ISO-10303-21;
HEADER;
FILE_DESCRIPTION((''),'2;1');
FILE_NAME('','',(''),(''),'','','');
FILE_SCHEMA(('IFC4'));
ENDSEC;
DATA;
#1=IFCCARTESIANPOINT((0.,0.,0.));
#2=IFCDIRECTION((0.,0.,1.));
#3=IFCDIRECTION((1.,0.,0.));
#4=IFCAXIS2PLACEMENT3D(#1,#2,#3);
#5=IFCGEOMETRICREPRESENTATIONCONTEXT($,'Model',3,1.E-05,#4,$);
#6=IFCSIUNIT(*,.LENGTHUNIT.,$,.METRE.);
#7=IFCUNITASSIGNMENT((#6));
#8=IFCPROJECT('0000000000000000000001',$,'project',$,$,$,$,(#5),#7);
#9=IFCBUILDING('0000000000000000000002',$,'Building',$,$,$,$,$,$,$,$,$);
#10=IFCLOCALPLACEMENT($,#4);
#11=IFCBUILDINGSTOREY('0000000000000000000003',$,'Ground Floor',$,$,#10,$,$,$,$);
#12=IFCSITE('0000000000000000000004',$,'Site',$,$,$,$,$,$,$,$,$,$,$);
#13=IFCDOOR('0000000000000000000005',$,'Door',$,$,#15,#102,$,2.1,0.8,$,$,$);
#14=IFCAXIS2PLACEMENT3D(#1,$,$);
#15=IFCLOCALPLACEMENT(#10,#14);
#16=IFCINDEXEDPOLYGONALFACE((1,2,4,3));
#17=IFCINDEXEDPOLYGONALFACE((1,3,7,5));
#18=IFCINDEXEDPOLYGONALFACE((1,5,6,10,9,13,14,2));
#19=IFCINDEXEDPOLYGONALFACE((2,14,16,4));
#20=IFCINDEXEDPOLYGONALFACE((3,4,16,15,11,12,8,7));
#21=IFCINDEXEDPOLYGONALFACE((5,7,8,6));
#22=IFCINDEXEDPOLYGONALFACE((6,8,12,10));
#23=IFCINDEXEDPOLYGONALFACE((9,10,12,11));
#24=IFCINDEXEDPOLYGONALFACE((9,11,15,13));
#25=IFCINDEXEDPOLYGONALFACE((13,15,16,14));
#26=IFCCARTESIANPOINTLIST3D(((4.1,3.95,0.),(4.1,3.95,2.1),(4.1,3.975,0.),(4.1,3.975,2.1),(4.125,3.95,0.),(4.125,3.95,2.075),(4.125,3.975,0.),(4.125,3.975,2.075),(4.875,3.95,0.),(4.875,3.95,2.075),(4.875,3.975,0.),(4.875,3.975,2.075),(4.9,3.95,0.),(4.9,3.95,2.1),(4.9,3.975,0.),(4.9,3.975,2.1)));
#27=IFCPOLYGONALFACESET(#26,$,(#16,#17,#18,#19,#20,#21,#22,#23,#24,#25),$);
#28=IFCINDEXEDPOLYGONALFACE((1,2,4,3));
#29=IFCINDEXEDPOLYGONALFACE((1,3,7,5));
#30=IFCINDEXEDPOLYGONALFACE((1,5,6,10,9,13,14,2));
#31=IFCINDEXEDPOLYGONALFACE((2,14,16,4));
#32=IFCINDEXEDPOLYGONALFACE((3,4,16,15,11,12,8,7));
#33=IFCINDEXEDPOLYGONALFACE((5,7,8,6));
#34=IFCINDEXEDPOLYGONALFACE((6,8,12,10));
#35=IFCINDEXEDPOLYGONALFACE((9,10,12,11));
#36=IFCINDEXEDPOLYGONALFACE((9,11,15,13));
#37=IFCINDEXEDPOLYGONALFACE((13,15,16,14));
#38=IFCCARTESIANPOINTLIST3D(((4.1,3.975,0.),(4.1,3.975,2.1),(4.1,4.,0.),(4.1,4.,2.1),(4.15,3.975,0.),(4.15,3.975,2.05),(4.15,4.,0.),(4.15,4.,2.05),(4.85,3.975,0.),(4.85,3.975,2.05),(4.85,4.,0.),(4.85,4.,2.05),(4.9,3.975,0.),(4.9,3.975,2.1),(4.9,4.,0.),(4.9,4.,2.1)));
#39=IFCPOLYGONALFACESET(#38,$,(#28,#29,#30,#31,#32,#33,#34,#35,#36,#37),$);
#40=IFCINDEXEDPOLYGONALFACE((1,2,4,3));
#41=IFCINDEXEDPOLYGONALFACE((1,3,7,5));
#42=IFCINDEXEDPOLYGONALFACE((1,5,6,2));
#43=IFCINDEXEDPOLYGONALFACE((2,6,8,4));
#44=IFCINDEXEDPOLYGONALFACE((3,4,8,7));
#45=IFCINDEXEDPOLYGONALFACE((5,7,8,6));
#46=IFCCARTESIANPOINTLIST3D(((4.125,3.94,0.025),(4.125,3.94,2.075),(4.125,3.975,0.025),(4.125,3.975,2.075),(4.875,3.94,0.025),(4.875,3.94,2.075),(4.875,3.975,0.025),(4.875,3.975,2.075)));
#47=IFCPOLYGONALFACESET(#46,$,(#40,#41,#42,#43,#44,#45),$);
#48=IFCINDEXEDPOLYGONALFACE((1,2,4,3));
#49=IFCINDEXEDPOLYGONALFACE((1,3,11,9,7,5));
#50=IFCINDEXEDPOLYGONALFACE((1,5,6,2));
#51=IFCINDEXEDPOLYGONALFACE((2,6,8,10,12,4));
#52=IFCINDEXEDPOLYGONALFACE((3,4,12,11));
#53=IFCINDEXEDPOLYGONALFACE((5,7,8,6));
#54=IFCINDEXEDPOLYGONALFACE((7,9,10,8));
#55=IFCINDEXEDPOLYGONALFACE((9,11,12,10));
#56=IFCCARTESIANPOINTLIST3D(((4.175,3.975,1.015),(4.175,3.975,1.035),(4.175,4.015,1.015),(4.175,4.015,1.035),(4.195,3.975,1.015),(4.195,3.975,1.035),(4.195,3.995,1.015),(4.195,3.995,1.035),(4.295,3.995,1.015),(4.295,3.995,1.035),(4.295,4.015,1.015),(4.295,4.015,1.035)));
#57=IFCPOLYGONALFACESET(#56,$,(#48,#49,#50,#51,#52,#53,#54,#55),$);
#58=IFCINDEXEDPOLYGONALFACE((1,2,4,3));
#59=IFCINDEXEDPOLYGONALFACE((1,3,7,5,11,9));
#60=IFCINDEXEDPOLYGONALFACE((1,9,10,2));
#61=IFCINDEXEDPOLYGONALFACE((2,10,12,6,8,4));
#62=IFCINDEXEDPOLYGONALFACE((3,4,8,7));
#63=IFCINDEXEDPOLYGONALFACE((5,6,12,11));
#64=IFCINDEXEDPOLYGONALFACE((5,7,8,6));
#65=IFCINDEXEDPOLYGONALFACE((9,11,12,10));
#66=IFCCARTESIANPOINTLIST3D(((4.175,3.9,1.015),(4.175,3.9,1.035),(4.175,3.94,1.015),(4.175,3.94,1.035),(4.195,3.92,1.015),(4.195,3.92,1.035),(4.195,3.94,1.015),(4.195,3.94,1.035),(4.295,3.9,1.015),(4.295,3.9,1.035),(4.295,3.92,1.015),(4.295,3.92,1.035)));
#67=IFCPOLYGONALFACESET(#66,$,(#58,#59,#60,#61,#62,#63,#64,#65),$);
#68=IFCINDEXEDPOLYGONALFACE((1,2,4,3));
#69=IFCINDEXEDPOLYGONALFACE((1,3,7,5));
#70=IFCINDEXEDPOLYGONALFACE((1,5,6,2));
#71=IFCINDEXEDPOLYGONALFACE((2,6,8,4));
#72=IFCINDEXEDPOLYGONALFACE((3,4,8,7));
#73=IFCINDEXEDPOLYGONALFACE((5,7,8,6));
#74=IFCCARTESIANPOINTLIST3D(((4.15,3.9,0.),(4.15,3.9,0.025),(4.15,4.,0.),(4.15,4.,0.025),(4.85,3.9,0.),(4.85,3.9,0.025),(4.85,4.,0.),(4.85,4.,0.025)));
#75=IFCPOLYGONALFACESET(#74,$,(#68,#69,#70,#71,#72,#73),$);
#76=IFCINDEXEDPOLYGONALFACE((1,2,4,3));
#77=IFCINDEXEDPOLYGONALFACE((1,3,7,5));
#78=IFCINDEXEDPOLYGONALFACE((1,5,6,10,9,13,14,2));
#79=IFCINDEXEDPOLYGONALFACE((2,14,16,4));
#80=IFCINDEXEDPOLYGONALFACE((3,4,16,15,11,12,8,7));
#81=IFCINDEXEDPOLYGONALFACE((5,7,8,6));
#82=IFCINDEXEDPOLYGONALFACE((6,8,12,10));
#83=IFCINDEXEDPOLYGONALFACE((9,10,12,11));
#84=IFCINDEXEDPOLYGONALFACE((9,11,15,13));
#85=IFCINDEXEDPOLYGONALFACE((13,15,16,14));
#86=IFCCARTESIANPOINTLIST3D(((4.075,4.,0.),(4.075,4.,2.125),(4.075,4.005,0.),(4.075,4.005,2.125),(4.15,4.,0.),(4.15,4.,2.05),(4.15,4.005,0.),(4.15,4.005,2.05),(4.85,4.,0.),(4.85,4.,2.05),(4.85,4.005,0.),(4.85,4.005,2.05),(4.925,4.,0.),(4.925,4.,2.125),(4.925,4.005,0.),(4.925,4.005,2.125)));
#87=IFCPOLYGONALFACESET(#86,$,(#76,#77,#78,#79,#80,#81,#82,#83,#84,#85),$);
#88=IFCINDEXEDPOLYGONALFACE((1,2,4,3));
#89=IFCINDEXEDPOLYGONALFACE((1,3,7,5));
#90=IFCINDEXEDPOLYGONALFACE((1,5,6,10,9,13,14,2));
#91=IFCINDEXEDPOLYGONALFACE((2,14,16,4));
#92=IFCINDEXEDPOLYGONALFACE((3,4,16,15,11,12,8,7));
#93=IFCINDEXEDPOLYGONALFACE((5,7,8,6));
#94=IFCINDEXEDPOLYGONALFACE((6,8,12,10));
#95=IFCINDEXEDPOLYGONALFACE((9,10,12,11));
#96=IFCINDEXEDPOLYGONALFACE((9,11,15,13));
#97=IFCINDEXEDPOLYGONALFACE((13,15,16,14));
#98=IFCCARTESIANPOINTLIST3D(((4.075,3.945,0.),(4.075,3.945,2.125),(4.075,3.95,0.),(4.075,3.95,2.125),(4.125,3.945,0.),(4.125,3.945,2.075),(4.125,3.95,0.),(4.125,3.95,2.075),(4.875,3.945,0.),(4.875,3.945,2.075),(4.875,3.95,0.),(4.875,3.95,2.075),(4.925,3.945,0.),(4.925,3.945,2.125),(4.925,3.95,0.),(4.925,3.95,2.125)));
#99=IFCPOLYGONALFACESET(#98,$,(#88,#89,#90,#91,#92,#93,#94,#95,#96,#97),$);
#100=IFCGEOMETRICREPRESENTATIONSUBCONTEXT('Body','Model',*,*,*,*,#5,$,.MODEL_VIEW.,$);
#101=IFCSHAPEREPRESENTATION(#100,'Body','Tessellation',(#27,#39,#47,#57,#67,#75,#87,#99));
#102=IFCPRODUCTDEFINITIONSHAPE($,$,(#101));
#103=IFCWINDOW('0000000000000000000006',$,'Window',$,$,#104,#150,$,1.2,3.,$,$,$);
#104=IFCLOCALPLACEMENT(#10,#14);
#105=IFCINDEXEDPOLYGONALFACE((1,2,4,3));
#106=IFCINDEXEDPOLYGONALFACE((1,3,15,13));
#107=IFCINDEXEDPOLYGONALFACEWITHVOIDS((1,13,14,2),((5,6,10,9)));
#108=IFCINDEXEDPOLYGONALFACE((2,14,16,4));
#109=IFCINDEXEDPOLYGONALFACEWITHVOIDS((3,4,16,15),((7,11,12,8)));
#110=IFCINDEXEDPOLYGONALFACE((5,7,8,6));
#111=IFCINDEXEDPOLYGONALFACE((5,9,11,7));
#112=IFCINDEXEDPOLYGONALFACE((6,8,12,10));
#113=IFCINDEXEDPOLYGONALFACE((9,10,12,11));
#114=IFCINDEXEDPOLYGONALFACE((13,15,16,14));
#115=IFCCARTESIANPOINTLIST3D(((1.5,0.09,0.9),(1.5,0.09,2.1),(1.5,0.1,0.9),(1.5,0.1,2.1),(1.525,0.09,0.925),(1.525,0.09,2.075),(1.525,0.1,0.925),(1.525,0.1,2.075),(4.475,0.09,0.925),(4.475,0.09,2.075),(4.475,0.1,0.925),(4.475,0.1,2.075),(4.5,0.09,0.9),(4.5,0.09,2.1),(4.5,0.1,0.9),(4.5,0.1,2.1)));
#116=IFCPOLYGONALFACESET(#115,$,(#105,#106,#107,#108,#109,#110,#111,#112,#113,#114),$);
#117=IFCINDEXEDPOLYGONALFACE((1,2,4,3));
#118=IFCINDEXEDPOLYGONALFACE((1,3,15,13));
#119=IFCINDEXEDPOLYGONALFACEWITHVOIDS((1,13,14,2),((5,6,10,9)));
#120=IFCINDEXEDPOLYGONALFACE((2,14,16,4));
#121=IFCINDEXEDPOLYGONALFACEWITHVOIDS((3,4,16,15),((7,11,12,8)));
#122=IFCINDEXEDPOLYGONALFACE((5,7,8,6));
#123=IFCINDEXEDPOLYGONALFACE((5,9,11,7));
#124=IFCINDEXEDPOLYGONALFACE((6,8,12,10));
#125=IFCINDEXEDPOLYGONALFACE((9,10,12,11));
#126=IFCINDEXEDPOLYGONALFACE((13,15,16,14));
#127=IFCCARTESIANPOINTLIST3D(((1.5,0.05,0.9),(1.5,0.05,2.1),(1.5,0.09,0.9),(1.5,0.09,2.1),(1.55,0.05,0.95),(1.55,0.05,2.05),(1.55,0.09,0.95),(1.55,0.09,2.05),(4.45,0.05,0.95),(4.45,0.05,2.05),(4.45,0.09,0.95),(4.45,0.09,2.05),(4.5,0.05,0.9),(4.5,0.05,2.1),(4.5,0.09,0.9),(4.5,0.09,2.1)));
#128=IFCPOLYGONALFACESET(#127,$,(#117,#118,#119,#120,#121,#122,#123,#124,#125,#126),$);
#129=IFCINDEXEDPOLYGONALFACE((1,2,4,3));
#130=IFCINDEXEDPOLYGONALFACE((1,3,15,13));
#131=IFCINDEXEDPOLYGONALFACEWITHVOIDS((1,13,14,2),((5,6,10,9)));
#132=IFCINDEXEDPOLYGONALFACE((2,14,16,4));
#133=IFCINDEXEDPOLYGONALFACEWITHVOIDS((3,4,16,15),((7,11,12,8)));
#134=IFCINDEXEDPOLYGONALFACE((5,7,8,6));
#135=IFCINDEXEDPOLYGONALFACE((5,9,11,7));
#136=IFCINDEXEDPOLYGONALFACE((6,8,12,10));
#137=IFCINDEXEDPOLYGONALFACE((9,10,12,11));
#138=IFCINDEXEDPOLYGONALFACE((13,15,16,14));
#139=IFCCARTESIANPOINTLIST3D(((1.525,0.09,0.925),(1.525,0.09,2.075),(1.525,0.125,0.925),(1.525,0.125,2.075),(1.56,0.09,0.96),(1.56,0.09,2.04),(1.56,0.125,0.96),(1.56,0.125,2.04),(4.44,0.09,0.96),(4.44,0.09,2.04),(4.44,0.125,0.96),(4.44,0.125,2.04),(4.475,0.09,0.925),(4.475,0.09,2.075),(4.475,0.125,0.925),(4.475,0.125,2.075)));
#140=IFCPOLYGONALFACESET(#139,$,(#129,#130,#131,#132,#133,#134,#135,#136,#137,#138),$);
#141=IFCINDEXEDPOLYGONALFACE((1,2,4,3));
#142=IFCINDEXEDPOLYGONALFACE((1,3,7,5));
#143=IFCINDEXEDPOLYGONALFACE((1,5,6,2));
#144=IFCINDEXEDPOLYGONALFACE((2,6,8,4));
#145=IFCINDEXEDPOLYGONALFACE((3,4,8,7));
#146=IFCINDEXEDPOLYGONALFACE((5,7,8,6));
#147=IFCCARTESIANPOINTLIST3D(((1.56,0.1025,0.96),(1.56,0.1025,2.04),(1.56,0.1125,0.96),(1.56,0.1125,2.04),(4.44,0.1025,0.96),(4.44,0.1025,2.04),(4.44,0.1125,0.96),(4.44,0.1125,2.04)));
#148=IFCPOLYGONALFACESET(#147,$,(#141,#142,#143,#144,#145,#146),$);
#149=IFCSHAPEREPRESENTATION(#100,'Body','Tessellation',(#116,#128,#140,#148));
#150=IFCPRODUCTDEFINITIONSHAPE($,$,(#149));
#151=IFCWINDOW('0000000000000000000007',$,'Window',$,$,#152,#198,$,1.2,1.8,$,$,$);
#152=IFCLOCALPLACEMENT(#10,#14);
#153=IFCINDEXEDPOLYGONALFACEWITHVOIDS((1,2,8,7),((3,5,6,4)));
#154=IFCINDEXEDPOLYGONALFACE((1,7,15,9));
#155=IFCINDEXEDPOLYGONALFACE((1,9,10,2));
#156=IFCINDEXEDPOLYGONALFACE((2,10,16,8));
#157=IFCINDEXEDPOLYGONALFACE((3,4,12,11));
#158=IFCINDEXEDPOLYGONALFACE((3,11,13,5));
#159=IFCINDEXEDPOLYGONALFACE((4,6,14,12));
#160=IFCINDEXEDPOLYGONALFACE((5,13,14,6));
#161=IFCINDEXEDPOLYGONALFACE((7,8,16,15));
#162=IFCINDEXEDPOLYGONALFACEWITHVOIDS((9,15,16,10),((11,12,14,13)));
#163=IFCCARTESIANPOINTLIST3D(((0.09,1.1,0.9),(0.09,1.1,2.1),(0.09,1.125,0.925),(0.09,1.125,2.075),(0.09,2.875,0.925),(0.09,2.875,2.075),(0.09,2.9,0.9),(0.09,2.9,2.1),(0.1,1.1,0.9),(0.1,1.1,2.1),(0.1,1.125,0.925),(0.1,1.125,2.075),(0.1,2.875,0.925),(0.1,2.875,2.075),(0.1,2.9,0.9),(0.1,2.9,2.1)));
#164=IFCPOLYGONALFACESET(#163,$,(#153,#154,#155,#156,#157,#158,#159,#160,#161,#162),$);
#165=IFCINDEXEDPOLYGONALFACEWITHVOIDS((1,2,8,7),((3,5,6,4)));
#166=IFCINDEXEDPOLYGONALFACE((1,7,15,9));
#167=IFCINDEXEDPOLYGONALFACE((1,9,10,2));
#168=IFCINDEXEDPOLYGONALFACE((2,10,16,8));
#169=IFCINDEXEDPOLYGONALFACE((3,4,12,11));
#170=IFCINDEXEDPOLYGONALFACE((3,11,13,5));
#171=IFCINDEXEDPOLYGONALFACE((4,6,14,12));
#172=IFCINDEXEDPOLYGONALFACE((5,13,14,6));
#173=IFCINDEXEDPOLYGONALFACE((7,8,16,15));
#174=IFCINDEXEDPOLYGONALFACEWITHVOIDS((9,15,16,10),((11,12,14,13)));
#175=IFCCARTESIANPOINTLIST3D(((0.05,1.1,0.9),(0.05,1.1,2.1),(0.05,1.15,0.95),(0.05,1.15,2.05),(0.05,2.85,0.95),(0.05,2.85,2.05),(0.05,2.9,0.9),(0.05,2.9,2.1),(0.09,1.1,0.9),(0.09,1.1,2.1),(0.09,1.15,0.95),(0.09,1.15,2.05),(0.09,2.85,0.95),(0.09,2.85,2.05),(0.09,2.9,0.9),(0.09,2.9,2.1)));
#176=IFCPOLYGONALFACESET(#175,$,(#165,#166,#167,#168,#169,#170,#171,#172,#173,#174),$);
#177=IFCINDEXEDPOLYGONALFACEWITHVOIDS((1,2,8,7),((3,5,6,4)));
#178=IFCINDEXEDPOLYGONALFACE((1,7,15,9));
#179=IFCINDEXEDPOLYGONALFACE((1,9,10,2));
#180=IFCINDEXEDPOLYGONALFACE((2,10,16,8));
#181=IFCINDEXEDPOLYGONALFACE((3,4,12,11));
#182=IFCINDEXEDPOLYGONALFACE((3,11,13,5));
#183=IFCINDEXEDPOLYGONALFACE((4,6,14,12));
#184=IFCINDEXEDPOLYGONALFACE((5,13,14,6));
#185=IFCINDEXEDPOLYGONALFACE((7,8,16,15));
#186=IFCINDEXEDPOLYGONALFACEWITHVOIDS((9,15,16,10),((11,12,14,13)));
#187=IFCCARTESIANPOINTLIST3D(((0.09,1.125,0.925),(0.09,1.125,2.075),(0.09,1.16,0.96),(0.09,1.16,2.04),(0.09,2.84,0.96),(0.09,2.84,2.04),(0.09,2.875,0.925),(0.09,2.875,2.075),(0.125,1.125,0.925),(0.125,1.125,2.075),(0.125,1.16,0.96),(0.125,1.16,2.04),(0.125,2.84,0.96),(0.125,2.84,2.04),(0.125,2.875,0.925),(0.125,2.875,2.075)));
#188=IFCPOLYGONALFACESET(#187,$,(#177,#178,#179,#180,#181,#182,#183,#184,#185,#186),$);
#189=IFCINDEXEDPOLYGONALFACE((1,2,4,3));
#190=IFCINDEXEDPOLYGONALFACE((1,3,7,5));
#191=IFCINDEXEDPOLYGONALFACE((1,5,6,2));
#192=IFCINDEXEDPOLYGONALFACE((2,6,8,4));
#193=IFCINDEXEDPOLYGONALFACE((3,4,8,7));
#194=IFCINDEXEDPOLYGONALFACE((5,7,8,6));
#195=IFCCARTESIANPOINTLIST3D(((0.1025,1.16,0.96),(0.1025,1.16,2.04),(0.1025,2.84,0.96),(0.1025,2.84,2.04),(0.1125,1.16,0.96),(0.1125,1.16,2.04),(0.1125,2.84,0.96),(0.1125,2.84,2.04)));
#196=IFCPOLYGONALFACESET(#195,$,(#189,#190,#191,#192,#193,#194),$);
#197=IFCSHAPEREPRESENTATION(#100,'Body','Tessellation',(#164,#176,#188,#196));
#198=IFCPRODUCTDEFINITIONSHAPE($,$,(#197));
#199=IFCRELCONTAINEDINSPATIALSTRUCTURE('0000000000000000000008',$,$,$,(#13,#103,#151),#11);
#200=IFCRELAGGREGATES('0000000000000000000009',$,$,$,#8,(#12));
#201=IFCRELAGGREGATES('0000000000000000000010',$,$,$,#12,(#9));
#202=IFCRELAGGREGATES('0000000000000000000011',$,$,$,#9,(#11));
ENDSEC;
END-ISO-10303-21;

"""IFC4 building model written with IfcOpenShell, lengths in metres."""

from ifc_helpers import new_model, si_unit, frame, origin_with_axes, place, context, subcontext, project, spatial, line, indexed_curve, outline, extrude, element, save


model = new_model("IFC4")

# Units and contexts
model_context = context("Model", 3, precision=1e-05, world=origin_with_axes())
body_context = subcontext(model_context, "Body", "Model", "MODEL_VIEW")
ifc_project = project(units=[si_unit("LENGTHUNIT", "METRE")], contexts=[model_context])

# Site, building, storey
site = spatial("IfcSite", under=ifc_project, Name="Site")
building = spatial("IfcBuilding", under=site, Name="Building")
storey_placement = place(None, origin_with_axes())
storey = spatial("IfcBuildingStorey", under=building, at=storey_placement, Name="Ground Floor")

# Door
door_1_placement = place(storey_placement, frame((4.9, 4.0, 0.0), z_axis=(0.0, 0.0, 1.0), x_axis=(-1.0, 0.0, 0.0)))
element("IfcDoor", 1, at=door_1_placement, inside=storey, Name="Door", OverallHeight=2.1, OverallWidth=0.8, context=body_context, shape_type="SweptSolid", body=[
    extrude(outline(indexed_curve([(0.0, 0.0), (0.0, 2.1), (0.8, 2.1), (0.8, 0.0), (0.775, 0.0), (0.775, 2.075), (0.025, 2.075), (0.025, 0.0)], segments=[line(1, 2, 3, 4, 5, 6, 7, 8, 1)])), frame((0.0, 0.025, 0.0), z_axis=(0.0, -1.0, 0.0), x_axis=(1.0, 0.0, 0.0)), (0.0, 0.0, -1.0), 0.025),
    extrude(outline(indexed_curve([(0.0, 0.0), (0.0, 2.1), (0.8, 2.1), (0.8, 0.0), (0.75, 0.0), (0.75, 2.05), (0.05, 2.05), (0.05, 0.0)], segments=[line(1, 2, 3, 4, 5, 6, 7, 8, 1)])), frame((0.0, 0.0, 0.0), z_axis=(0.0, -1.0, 0.0), x_axis=(1.0, 0.0, 0.0)), (0.0, 0.0, -1.0), 0.025),
    extrude(outline(indexed_curve([(0.0, 0.0), (0.75, 0.0), (0.75, 0.035), (0.0, 0.035)], segments=[line(1, 2, 3, 4, 1)])), frame((0.025, 0.025, 0.025), z_axis=(0.0, 0.0, 1.0), x_axis=(1.0, 0.0, 0.0)), (0.0, 0.0, 1.0), 2.05),
    extrude(outline(indexed_curve([(0.0, 0.0), (0.0, -0.04), (-0.12, -0.04), (-0.12, -0.02), (-0.02, -0.02), (-0.02, 0.0)], segments=[line(1, 2, 3, 4, 5, 6, 1)])), frame((0.725, 0.025, 1.015), z_axis=(0.0, 0.0, 1.0), x_axis=(1.0, 0.0, 0.0)), (0.0, 0.0, 1.0), 0.02),
    extrude(outline(indexed_curve([(0.0, 0.0), (0.0, 0.04), (-0.12, 0.04), (-0.12, 0.02), (-0.02, 0.02), (-0.02, 0.0)], segments=[line(1, 2, 3, 4, 5, 6, 1)])), frame((0.725, 0.06, 1.015), z_axis=(0.0, 0.0, 1.0), x_axis=(1.0, 0.0, 0.0)), (0.0, 0.0, 1.0), 0.02),
    extrude(outline(indexed_curve([(0.0, 0.0), (0.7, 0.0), (0.7, 0.1), (0.0, 0.1)], segments=[line(1, 2, 3, 4, 1)])), frame((0.05, 0.0, 0.0), z_axis=(0.0, 0.0, 1.0), x_axis=(1.0, 0.0, 0.0)), (0.0, 0.0, 1.0), 0.025),
    extrude(outline(indexed_curve([(0.0, 0.0), (0.0, 2.125), (0.85, 2.125), (0.85, 0.0), (0.775, 0.0), (0.775, 2.05), (0.075, 2.05), (0.075, 0.0)], segments=[line(1, 2, 3, 4, 5, 6, 7, 8, 1)])), frame((-0.025, -0.005, 0.0), z_axis=(0.0, -1.0, 0.0), x_axis=(1.0, 0.0, 0.0)), (0.0, 0.0, -1.0), 0.005),
    extrude(outline(indexed_curve([(0.0, 0.0), (0.0, 2.125), (0.85, 2.125), (0.85, 0.0), (0.8, 0.0), (0.8, 2.075), (0.05, 2.075), (0.05, 0.0)], segments=[line(1, 2, 3, 4, 5, 6, 7, 8, 1)])), frame((-0.025, 0.05, 0.0), z_axis=(0.0, -1.0, 0.0), x_axis=(1.0, 0.0, 0.0)), (0.0, 0.0, -1.0), 0.005),
])

# Windows
window_1_placement = place(storey_placement, frame((1.5, 0.0, 0.9), z_axis=(0.0, 0.0, 1.0), x_axis=(1.0, 0.0, 0.0)))
element("IfcWindow", 2, at=window_1_placement, inside=storey, Name="Window", OverallHeight=1.2, OverallWidth=3.0, context=body_context, shape_type="SweptSolid", body=[
    extrude(outline(indexed_curve([(0.0, 0.0), (3.0, 0.0), (3.0, 1.2), (0.0, 1.2)], segments=[line(1, 2, 3, 4, 1)]), holes=[indexed_curve([(0.025, 0.025), (2.975, 0.025), (2.975, 1.175), (0.025, 1.175)], segments=[line(1, 2, 3, 4, 1)])]), frame((0.0, 0.09, 0.0), z_axis=(0.0, -1.0, 0.0), x_axis=(1.0, 0.0, 0.0)), (0.0, 0.0, -1.0), 0.01),
    extrude(outline(indexed_curve([(0.0, 0.0), (3.0, 0.0), (3.0, 1.2), (0.0, 1.2)], segments=[line(1, 2, 3, 4, 1)]), holes=[indexed_curve([(0.05, 0.05), (2.95, 0.05), (2.95, 1.15), (0.05, 1.15)], segments=[line(1, 2, 3, 4, 1)])]), frame((0.0, 0.05, 0.0), z_axis=(0.0, -1.0, 0.0), x_axis=(1.0, 0.0, 0.0)), (0.0, 0.0, -1.0), 0.04),
    extrude(outline(indexed_curve([(0.0, 0.0), (2.95, 0.0), (2.95, 1.15), (0.0, 1.15)], segments=[line(1, 2, 3, 4, 1)]), holes=[indexed_curve([(0.035, 0.035), (2.915, 0.035), (2.915, 1.115), (0.035, 1.115)], segments=[line(1, 2, 3, 4, 1)])]), frame((0.025, 0.09, 0.025), z_axis=(0.0, -1.0, 0.0), x_axis=(1.0, 0.0, 0.0)), (0.0, 0.0, -1.0), 0.035),
    extrude(outline(indexed_curve([(0.035, 0.035), (2.915, 0.035), (2.915, 1.115), (0.035, 1.115)], segments=[line(1, 2, 3, 4, 1)])), frame((0.025, 0.1025, 0.025), z_axis=(0.0, -1.0, 0.0), x_axis=(1.0, 0.0, 0.0)), (0.0, 0.0, -1.0), 0.01),
])
for number, where, z_axis, x_axis, name in (
    (3, (0.0, 2.9, 0.9), (0.0, 0.0, 1.0), (0.0, -1.0, 0.0), "Window"),
):
    element("IfcWindow", number, at=place(storey_placement, frame(where, z_axis=z_axis, x_axis=x_axis)), inside=storey, Name=name, OverallHeight=1.2, OverallWidth=1.8, context=body_context, shape_type="SweptSolid", body=[
        extrude(outline(indexed_curve([(0.0, 0.0), (1.8, 0.0), (1.8, 1.2), (0.0, 1.2)], segments=[line(1, 2, 3, 4, 1)]), holes=[indexed_curve([(0.025, 0.025), (1.775, 0.025), (1.775, 1.175), (0.025, 1.175)], segments=[line(1, 2, 3, 4, 1)])]), frame((0.0, 0.09, 0.0), z_axis=(0.0, -1.0, 0.0), x_axis=(1.0, 0.0, 0.0)), (0.0, 0.0, -1.0), 0.01),
        extrude(outline(indexed_curve([(0.0, 0.0), (1.8, 0.0), (1.8, 1.2), (0.0, 1.2)], segments=[line(1, 2, 3, 4, 1)]), holes=[indexed_curve([(0.05, 0.05), (1.75, 0.05), (1.75, 1.15), (0.05, 1.15)], segments=[line(1, 2, 3, 4, 1)])]), frame((0.0, 0.05, 0.0), z_axis=(0.0, -1.0, 0.0), x_axis=(1.0, 0.0, 0.0)), (0.0, 0.0, -1.0), 0.04),
        extrude(outline(indexed_curve([(0.0, 0.0), (1.75, 0.0), (1.75, 1.15), (0.0, 1.15)], segments=[line(1, 2, 3, 4, 1)]), holes=[indexed_curve([(0.035, 0.035), (1.715, 0.035), (1.715, 1.115), (0.035, 1.115)], segments=[line(1, 2, 3, 4, 1)])]), frame((0.025, 0.09, 0.025), z_axis=(0.0, -1.0, 0.0), x_axis=(1.0, 0.0, 0.0)), (0.0, 0.0, -1.0), 0.035),
        extrude(outline(indexed_curve([(0.035, 0.035), (1.715, 0.035), (1.715, 1.115), (0.035, 1.115)], segments=[line(1, 2, 3, 4, 1)])), frame((0.025, 0.1025, 0.025), z_axis=(0.0, -1.0, 0.0), x_axis=(1.0, 0.0, 0.0)), (0.0, 0.0, -1.0), 0.01),
    ])

save(model, "model.ifc")
